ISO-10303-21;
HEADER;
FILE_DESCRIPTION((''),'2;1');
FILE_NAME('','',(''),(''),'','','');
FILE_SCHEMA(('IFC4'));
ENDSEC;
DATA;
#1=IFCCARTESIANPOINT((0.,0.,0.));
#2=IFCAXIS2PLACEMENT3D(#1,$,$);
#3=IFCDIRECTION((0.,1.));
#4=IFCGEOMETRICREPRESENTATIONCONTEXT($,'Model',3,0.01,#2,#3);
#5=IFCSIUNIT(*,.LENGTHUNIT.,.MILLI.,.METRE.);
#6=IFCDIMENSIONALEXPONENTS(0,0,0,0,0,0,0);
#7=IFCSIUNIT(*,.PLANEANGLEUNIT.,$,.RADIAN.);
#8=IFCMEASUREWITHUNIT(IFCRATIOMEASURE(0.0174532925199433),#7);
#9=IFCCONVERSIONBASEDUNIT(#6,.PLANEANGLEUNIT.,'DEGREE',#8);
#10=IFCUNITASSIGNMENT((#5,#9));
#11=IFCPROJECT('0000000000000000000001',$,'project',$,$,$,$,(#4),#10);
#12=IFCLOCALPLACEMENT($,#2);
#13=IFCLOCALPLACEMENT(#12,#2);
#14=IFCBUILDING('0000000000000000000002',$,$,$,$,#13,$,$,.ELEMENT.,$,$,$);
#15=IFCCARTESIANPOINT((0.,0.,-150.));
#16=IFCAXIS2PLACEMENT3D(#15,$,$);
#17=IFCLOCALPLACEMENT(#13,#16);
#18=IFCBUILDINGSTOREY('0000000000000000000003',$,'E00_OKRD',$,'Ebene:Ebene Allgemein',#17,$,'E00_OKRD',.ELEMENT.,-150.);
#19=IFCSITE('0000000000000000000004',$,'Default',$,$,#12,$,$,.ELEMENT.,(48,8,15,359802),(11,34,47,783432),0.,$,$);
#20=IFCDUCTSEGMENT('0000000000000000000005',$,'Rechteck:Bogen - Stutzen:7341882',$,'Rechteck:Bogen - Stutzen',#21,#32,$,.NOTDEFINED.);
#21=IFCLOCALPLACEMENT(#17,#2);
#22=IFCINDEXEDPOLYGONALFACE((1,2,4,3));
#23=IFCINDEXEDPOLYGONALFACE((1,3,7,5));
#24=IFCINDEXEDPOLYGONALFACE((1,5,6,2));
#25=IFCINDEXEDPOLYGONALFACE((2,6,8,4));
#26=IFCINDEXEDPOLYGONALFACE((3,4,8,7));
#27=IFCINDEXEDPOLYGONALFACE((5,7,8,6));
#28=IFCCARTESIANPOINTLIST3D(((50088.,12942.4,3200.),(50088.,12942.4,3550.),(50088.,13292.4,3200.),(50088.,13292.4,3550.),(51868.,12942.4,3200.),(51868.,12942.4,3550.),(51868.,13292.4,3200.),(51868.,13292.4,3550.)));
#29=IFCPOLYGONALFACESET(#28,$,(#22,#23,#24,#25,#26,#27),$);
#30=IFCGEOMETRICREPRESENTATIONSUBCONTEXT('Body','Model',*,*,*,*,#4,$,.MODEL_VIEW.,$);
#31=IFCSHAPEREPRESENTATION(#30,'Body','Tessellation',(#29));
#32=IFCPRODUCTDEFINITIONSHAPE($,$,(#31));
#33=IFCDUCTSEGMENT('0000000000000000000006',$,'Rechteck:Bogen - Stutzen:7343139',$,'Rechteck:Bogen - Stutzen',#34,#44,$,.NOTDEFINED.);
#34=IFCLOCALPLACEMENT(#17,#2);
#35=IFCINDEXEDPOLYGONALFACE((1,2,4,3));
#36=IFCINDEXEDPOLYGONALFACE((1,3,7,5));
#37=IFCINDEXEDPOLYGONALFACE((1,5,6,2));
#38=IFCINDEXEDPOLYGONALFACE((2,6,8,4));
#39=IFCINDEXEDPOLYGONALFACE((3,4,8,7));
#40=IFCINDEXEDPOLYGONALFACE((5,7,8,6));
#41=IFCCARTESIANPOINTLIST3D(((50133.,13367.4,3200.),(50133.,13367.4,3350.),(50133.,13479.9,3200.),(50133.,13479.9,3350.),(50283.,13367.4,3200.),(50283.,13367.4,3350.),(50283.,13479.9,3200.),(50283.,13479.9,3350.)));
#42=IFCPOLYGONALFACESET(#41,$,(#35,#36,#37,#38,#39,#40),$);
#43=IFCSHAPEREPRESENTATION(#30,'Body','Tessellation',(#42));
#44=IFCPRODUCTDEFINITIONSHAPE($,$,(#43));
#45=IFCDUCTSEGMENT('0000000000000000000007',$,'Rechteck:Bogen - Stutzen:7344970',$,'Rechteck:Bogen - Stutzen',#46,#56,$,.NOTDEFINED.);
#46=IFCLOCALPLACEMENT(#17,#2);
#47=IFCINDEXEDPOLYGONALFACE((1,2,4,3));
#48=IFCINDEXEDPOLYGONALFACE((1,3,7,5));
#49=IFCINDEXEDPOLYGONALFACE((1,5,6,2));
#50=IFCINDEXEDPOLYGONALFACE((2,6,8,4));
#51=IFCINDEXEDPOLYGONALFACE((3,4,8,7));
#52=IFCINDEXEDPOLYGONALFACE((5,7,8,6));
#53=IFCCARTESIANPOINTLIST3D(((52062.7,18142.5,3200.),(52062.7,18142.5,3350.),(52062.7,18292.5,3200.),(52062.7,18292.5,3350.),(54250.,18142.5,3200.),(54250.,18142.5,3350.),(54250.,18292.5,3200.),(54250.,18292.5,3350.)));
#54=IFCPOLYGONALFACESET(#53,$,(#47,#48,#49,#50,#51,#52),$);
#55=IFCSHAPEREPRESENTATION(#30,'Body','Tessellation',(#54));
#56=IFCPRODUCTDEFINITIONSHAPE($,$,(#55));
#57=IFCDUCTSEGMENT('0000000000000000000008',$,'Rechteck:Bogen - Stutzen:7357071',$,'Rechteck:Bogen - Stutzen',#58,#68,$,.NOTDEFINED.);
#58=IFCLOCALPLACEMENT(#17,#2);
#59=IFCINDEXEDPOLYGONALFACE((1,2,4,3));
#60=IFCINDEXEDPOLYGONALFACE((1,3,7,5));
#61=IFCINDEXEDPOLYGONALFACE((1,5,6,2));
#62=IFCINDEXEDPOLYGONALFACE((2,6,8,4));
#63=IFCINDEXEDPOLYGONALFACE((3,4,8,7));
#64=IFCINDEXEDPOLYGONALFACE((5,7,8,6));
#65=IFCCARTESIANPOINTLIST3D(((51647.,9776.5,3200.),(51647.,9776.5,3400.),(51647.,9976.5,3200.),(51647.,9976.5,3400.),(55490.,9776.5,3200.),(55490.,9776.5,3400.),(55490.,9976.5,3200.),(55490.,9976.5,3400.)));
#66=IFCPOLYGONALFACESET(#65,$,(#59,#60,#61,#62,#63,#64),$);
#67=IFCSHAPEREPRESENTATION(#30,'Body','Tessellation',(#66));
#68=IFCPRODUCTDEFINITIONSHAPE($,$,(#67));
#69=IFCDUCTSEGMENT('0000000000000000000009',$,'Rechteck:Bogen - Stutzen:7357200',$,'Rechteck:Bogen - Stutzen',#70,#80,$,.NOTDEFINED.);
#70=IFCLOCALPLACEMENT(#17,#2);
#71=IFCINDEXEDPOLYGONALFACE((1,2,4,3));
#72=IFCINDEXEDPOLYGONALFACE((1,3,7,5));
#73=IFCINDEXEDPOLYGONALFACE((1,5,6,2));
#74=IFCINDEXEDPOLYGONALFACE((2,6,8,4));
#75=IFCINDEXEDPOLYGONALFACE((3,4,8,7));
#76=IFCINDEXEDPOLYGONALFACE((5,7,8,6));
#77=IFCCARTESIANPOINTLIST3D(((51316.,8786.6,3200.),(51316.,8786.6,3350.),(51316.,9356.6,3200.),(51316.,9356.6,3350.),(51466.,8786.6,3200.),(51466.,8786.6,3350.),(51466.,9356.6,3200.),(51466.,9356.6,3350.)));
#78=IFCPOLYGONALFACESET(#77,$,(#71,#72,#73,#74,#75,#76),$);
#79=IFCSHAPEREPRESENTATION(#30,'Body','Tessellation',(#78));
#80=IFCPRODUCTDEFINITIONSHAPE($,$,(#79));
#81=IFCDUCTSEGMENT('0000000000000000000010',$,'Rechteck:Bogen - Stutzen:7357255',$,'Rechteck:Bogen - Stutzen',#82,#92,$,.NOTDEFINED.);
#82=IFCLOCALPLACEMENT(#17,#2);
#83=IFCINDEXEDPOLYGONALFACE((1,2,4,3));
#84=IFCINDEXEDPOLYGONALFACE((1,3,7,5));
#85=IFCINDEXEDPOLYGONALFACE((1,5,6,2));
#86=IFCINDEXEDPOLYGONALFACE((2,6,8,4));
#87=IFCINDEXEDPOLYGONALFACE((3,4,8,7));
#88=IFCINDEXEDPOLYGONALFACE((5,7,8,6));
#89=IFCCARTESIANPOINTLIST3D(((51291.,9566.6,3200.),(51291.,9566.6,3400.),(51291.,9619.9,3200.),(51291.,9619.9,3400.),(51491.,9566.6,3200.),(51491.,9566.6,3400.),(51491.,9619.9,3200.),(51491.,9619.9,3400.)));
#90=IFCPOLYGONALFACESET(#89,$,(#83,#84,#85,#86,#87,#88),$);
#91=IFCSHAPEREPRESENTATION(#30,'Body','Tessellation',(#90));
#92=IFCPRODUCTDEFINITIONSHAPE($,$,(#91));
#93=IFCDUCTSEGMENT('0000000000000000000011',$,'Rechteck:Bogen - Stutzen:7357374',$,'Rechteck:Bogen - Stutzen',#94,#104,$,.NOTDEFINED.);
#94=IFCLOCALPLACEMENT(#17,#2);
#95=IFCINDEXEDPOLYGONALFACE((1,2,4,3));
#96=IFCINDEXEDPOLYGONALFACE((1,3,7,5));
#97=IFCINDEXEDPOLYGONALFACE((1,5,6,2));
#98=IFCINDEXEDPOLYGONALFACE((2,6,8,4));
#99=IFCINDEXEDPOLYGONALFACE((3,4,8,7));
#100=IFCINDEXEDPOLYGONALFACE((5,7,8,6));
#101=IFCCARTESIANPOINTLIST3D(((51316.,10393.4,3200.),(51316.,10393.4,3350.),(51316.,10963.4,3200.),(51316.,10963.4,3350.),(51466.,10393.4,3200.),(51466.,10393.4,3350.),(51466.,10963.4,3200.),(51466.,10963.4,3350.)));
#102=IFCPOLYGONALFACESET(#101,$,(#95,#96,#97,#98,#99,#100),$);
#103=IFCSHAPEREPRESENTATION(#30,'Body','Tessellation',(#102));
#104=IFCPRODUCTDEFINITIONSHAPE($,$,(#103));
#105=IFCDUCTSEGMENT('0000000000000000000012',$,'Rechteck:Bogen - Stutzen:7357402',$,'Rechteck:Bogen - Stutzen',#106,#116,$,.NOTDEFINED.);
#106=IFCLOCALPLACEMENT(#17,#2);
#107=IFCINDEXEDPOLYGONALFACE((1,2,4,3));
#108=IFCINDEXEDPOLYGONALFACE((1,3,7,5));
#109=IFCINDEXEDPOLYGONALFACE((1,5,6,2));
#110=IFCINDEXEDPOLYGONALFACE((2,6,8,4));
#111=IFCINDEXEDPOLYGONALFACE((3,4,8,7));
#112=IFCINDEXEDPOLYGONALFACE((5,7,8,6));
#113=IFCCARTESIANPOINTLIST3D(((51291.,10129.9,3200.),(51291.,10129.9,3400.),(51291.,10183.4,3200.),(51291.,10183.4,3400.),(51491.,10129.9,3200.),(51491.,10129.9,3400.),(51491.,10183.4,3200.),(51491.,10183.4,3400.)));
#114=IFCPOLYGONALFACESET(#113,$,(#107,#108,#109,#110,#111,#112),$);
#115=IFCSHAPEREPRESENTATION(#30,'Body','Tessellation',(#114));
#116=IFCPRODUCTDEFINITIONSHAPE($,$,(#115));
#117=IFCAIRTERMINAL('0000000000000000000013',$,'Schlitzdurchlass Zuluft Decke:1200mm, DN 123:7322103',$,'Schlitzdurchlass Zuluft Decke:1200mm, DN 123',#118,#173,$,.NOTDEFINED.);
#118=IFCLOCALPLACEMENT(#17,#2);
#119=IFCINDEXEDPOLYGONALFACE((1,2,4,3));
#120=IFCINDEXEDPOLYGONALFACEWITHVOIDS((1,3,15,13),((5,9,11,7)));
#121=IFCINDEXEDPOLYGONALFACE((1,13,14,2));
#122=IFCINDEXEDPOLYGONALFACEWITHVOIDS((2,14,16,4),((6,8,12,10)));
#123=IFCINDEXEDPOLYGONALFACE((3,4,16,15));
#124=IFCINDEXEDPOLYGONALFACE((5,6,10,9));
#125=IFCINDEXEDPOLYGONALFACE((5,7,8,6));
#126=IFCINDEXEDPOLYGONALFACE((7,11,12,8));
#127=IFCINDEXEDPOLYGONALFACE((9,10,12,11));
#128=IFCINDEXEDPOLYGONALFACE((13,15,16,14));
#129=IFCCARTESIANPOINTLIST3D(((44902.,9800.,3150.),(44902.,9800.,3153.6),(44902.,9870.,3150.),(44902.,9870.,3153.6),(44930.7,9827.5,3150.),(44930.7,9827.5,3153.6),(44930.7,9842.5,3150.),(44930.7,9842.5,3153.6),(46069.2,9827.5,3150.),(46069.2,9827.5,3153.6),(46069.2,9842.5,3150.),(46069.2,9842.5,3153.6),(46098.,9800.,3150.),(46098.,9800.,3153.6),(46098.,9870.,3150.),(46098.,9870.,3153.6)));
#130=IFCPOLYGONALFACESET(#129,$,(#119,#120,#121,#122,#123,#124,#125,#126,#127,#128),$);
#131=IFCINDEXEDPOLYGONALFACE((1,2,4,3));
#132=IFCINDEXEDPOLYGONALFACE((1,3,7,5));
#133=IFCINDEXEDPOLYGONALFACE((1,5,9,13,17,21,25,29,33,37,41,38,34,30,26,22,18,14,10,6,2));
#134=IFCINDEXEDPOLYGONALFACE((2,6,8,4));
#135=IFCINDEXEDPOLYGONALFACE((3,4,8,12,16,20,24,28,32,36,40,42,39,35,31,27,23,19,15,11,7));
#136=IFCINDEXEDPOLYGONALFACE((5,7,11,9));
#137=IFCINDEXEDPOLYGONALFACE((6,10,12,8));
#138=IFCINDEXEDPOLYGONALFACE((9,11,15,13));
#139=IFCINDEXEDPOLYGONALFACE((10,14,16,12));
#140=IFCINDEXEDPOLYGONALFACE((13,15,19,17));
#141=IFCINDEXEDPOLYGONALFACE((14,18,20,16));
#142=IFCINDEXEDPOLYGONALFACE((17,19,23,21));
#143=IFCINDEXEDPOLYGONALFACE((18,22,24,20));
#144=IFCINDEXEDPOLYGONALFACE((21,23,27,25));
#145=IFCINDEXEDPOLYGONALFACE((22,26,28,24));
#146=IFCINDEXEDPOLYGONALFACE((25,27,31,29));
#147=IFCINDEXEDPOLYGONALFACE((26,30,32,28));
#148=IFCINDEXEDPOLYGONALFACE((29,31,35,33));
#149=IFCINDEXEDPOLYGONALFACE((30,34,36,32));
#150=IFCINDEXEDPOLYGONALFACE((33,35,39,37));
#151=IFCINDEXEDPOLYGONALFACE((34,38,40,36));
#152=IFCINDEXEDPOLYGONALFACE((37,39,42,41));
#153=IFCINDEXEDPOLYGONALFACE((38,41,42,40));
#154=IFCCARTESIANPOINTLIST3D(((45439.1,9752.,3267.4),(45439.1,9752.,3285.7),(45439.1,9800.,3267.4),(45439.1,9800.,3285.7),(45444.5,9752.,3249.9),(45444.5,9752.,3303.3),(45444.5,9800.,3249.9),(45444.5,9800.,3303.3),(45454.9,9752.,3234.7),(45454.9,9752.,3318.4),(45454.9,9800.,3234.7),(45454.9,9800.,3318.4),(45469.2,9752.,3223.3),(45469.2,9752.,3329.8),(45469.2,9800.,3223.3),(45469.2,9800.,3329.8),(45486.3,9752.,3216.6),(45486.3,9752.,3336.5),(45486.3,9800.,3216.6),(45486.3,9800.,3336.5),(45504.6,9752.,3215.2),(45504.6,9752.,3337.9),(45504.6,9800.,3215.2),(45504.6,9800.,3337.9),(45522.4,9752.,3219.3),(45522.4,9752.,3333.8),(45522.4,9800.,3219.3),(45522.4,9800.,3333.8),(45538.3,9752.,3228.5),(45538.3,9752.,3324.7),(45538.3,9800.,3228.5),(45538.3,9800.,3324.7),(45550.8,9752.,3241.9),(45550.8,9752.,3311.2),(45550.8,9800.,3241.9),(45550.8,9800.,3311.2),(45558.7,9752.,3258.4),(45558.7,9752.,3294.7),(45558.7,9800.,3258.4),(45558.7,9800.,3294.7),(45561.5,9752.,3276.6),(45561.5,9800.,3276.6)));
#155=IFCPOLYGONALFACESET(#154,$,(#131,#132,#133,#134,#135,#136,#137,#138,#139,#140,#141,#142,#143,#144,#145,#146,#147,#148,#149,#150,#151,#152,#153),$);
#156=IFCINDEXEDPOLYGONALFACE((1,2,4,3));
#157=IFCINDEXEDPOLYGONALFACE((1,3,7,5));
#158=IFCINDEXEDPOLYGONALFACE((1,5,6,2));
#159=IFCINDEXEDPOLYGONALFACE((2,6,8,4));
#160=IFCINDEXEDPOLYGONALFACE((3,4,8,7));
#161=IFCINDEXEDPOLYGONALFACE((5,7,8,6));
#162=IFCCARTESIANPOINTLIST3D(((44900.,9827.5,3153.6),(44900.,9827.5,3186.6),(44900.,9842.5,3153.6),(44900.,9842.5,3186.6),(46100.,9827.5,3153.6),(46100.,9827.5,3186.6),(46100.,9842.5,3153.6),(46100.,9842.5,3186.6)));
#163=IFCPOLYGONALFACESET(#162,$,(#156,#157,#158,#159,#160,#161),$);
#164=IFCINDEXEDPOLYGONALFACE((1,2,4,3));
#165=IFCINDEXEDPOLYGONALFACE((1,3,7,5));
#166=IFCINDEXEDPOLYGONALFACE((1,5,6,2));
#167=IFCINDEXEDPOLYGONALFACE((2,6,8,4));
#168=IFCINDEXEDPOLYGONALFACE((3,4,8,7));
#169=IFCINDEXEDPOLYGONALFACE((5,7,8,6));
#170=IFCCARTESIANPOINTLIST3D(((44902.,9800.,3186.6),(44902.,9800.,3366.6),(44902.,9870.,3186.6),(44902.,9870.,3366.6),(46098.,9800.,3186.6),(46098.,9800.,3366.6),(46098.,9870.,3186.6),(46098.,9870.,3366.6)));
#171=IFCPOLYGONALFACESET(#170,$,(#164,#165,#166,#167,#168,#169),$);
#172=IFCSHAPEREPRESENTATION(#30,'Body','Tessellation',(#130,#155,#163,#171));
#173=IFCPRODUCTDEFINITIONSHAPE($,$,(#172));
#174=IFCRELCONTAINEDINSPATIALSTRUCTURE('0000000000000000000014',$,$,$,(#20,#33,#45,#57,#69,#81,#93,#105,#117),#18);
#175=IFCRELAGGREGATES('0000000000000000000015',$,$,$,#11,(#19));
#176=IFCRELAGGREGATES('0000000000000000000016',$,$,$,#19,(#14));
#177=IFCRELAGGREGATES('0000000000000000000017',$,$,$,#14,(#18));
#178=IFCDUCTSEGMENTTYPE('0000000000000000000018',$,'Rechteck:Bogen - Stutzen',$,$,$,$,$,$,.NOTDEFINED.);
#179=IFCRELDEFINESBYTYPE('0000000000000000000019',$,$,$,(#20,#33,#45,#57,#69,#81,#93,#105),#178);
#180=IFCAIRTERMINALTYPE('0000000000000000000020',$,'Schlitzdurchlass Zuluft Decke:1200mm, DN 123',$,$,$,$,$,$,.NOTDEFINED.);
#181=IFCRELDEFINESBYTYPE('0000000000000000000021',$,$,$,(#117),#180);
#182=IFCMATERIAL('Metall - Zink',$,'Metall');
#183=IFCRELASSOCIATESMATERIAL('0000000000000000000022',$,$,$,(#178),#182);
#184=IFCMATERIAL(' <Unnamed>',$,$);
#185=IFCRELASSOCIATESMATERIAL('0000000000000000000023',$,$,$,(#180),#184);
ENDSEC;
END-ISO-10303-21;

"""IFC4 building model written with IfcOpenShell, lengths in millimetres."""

from ifc_helpers import new_model, entity, si_unit, converted_unit, direction, frame, frame_2d, origin, origin_2d_with_axis, place, context, subcontext, project, spatial, polyline, rectangle, circle, outline, extrude, source, transform, mapped, material, type_object, type_shapes, element, save


model = new_model("IFC4")

# Units and contexts
model_context = context("Model", 3, precision=0.01, world=origin(), true_north=direction((0.0, 1.0)))
body_context = subcontext(model_context, "Body", "Model", "MODEL_VIEW")
ifc_project = project(units=[si_unit("LENGTHUNIT", "METRE", prefix="MILLI"), converted_unit("PLANEANGLEUNIT", "DEGREE", entity("IfcRatioMeasure", 0.0174532925199433), si_unit("PLANEANGLEUNIT", "RADIAN"), dimensions=[0, 0, 0, 0, 0, 0, 0])], contexts=[model_context])

# Site, building, storey
site_placement = place(None, origin())
site = spatial("IfcSite", under=ifc_project, at=site_placement, Name="Default", CompositionType="ELEMENT", RefLatitude=(48, 8, 15, 359802), RefLongitude=(11, 34, 47, 783432), RefElevation=0.0)
building_placement = place(site_placement, origin())
building = spatial("IfcBuilding", under=site, at=building_placement, CompositionType="ELEMENT")
storey_placement = place(building_placement, frame((0.0, 0.0, -150.0)))
storey = spatial("IfcBuildingStorey", under=building, at=storey_placement, Name="E00_OKRD", ObjectType="Ebene:Ebene Allgemein", LongName="E00_OKRD", CompositionType="ELEMENT", Elevation=-150.0)

# Duct segments
ifc_material_1 = material(Name="Metall - Zink", Category="Metall")
duct_segment_type_1 = type_object("IfcDuctSegmentType", Name="Rechteck:Bogen - Stutzen", PredefinedType="NOTDEFINED", material=ifc_material_1)
duct_segment_1_placement = place(storey_placement, frame((50088.0, 12942.4, 3200.0)))
element("IfcDuctSegment", 1, at=duct_segment_1_placement, inside=storey, type_object=duct_segment_type_1, Name="Rechteck:Bogen - Stutzen:7341882", ObjectType="Rechteck:Bogen - Stutzen", PredefinedType="NOTDEFINED", context=body_context, shape_type="SweptSolid", body=[
    extrude(rectangle(XDim=1780.0, YDim=350.0, at=frame_2d((0.0, 0.0), x_axis=(1.0, 0.0))), frame((890.0, 175.0, 0.0)), (0.0, 0.0, 1.0), 350.0),
])
duct_segment_2_placement = place(storey_placement, frame((50133.0, 13367.4, 3200.0)))
element("IfcDuctSegment", 2, at=duct_segment_2_placement, inside=storey, type_object=duct_segment_type_1, Name="Rechteck:Bogen - Stutzen:7343139", ObjectType="Rechteck:Bogen - Stutzen", PredefinedType="NOTDEFINED", context=body_context, shape_type="SweptSolid", body=[
    extrude(rectangle(XDim=112.5, YDim=150.0, at=origin_2d_with_axis()), frame((75.0, 56.2, 0.0), z_axis=(0.0, 0.0, 1.0), x_axis=(0.0, 1.0, 0.0)), (0.0, 0.0, 1.0), 150.0),
])
duct_segment_3_placement = place(storey_placement, frame((52062.7, 18142.5, 3200.0)))
element("IfcDuctSegment", 3, at=duct_segment_3_placement, inside=storey, type_object=duct_segment_type_1, Name="Rechteck:Bogen - Stutzen:7344970", ObjectType="Rechteck:Bogen - Stutzen", PredefinedType="NOTDEFINED", context=body_context, shape_type="SweptSolid", body=[
    extrude(rectangle(XDim=2187.2, YDim=150.0, at=frame_2d((0.0, 0.0), x_axis=(1.0, 0.0))), frame((1093.6, 75.0, 0.0)), (0.0, 0.0, 1.0), 150.0),
])
duct_segment_4_placement = place(storey_placement, frame((51647.0, 9776.5, 3200.0)))
element("IfcDuctSegment", 4, at=duct_segment_4_placement, inside=storey, type_object=duct_segment_type_1, Name="Rechteck:Bogen - Stutzen:7357071", ObjectType="Rechteck:Bogen - Stutzen", PredefinedType="NOTDEFINED", context=body_context, shape_type="SweptSolid", body=[
    extrude(rectangle(XDim=3843.0, YDim=200.0, at=frame_2d((0.0, 0.0), x_axis=(1.0, 0.0))), frame((1921.5, 100.0, 0.0)), (0.0, 0.0, 1.0), 200.0),
])
duct_segment_5_placement = place(storey_placement, frame((51316.0, 8786.6, 3200.0)))
element("IfcDuctSegment", 5, at=duct_segment_5_placement, inside=storey, type_object=duct_segment_type_1, Name="Rechteck:Bogen - Stutzen:7357200", ObjectType="Rechteck:Bogen - Stutzen", PredefinedType="NOTDEFINED", context=body_context, shape_type="SweptSolid", body=[
    extrude(rectangle(XDim=570.0, YDim=150.0, at=frame_2d((0.0, 0.0), x_axis=(1.0, 0.0))), frame((75.0, 285.0, 0.0), z_axis=(0.0, 0.0, 1.0), x_axis=(0.0, 1.0, 0.0)), (0.0, 0.0, 1.0), 150.0),
])
duct_segment_6_placement = place(storey_placement, frame((51291.0, 9566.6, 3200.0)))
element("IfcDuctSegment", 6, at=duct_segment_6_placement, inside=storey, type_object=duct_segment_type_1, Name="Rechteck:Bogen - Stutzen:7357255", ObjectType="Rechteck:Bogen - Stutzen", PredefinedType="NOTDEFINED", context=body_context, shape_type="SweptSolid", body=[
    extrude(rectangle(XDim=53.2, YDim=200.0, at=frame_2d((0.0, 0.0), x_axis=(1.0, 0.0))), frame((100.0, 26.6, 0.0), z_axis=(0.0, 0.0, 1.0), x_axis=(0.0, 1.0, 0.0)), (0.0, 0.0, 1.0), 200.0),
])
duct_segment_7_placement = place(storey_placement, frame((51316.0, 10393.4, 3200.0)))
element("IfcDuctSegment", 7, at=duct_segment_7_placement, inside=storey, type_object=duct_segment_type_1, Name="Rechteck:Bogen - Stutzen:7357374", ObjectType="Rechteck:Bogen - Stutzen", PredefinedType="NOTDEFINED", context=body_context, shape_type="SweptSolid", body=[
    extrude(rectangle(XDim=570.0, YDim=150.0, at=frame_2d((0.0, 0.0), x_axis=(1.0, 0.0))), frame((75.0, 285.0, 0.0), z_axis=(0.0, 0.0, 1.0), x_axis=(0.0, -1.0, 0.0)), (0.0, 0.0, 1.0), 150.0),
])
duct_segment_8_placement = place(storey_placement, frame((51291.0, 10129.9, 3200.0)))
element("IfcDuctSegment", 8, at=duct_segment_8_placement, inside=storey, type_object=duct_segment_type_1, Name="Rechteck:Bogen - Stutzen:7357402", ObjectType="Rechteck:Bogen - Stutzen", PredefinedType="NOTDEFINED", context=body_context, shape_type="SweptSolid", body=[
    extrude(rectangle(XDim=53.5, YDim=200.0, at=origin_2d_with_axis()), frame((100.0, 26.7, 0.0), z_axis=(0.0, 0.0, 1.0), x_axis=(0.0, -1.0, 0.0)), (0.0, 0.0, 1.0), 200.0),
])

# Air terminal
ifc_material_2 = material(Name=" <Unnamed>")
air_terminal_type_1 = type_object("IfcAirTerminalType", Name="Schlitzdurchlass Zuluft Decke:1200mm, DN 123", PredefinedType="NOTDEFINED", material=ifc_material_2)
shared_shape_1 = source(origin(), body_context, "Body", "SweptSolid", [
    extrude(outline(polyline([(-598.0, -35.0), (598.0, -35.0), (598.0, 35.0), (-598.0, 35.0), (-598.0, -35.0)]), holes=[polyline([(-569.2, -7.5), (-569.2, 7.5), (569.2, 7.5), (569.2, -7.5), (-569.2, -7.5)])]), frame((600.0, 35.0, 0.0), z_axis=(0.0, 0.0, 1.0), x_axis=(-1.0, 0.0, 0.0)), (0.0, 0.0, 1.0), 3.6),
    extrude(circle(Radius=61.5, at=frame_2d((0.0, 0.0), x_axis=(1.0, 0.0))), frame((600.0, 70.0, 126.6), z_axis=(0.0, 1.0, 0.0), x_axis=(-1.0, 0.0, 0.0)), (0.0, 0.0, 1.0), 48.0),
    extrude(rectangle(XDim=1200.0, YDim=15.0, at=origin_2d_with_axis()), frame((600.0, 35.0, 3.6), z_axis=(0.0, 0.0, 1.0), x_axis=(-1.0, 0.0, 0.0)), (0.0, 0.0, 1.0), 33.0),
    extrude(rectangle(XDim=1196.0, YDim=70.0, at=origin_2d_with_axis()), frame((600.0, 35.0, 36.6), z_axis=(0.0, 0.0, 1.0), x_axis=(-1.0, 0.0, 0.0)), (0.0, 0.0, 1.0), 180.0),
])
type_shapes(air_terminal_type_1, [shared_shape_1])
air_terminal_1_placement = place(storey_placement, frame((46100.0, 9870.0, 3150.0), z_axis=(0.0, 0.0, 1.0), x_axis=(-1.0, 0.0, 0.0)))
element("IfcAirTerminal", 9, at=air_terminal_1_placement, inside=storey, type_object=air_terminal_type_1, Name="Schlitzdurchlass Zuluft Decke:1200mm, DN 123:7322103", ObjectType="Schlitzdurchlass Zuluft Decke:1200mm, DN 123", PredefinedType="NOTDEFINED", context=body_context, shape_type="MappedRepresentation", body=[
    mapped(shared_shape_1, transform((0.0, 0.0, 0.0), scale=1.0)),
])

save(model, "model.ifc")
